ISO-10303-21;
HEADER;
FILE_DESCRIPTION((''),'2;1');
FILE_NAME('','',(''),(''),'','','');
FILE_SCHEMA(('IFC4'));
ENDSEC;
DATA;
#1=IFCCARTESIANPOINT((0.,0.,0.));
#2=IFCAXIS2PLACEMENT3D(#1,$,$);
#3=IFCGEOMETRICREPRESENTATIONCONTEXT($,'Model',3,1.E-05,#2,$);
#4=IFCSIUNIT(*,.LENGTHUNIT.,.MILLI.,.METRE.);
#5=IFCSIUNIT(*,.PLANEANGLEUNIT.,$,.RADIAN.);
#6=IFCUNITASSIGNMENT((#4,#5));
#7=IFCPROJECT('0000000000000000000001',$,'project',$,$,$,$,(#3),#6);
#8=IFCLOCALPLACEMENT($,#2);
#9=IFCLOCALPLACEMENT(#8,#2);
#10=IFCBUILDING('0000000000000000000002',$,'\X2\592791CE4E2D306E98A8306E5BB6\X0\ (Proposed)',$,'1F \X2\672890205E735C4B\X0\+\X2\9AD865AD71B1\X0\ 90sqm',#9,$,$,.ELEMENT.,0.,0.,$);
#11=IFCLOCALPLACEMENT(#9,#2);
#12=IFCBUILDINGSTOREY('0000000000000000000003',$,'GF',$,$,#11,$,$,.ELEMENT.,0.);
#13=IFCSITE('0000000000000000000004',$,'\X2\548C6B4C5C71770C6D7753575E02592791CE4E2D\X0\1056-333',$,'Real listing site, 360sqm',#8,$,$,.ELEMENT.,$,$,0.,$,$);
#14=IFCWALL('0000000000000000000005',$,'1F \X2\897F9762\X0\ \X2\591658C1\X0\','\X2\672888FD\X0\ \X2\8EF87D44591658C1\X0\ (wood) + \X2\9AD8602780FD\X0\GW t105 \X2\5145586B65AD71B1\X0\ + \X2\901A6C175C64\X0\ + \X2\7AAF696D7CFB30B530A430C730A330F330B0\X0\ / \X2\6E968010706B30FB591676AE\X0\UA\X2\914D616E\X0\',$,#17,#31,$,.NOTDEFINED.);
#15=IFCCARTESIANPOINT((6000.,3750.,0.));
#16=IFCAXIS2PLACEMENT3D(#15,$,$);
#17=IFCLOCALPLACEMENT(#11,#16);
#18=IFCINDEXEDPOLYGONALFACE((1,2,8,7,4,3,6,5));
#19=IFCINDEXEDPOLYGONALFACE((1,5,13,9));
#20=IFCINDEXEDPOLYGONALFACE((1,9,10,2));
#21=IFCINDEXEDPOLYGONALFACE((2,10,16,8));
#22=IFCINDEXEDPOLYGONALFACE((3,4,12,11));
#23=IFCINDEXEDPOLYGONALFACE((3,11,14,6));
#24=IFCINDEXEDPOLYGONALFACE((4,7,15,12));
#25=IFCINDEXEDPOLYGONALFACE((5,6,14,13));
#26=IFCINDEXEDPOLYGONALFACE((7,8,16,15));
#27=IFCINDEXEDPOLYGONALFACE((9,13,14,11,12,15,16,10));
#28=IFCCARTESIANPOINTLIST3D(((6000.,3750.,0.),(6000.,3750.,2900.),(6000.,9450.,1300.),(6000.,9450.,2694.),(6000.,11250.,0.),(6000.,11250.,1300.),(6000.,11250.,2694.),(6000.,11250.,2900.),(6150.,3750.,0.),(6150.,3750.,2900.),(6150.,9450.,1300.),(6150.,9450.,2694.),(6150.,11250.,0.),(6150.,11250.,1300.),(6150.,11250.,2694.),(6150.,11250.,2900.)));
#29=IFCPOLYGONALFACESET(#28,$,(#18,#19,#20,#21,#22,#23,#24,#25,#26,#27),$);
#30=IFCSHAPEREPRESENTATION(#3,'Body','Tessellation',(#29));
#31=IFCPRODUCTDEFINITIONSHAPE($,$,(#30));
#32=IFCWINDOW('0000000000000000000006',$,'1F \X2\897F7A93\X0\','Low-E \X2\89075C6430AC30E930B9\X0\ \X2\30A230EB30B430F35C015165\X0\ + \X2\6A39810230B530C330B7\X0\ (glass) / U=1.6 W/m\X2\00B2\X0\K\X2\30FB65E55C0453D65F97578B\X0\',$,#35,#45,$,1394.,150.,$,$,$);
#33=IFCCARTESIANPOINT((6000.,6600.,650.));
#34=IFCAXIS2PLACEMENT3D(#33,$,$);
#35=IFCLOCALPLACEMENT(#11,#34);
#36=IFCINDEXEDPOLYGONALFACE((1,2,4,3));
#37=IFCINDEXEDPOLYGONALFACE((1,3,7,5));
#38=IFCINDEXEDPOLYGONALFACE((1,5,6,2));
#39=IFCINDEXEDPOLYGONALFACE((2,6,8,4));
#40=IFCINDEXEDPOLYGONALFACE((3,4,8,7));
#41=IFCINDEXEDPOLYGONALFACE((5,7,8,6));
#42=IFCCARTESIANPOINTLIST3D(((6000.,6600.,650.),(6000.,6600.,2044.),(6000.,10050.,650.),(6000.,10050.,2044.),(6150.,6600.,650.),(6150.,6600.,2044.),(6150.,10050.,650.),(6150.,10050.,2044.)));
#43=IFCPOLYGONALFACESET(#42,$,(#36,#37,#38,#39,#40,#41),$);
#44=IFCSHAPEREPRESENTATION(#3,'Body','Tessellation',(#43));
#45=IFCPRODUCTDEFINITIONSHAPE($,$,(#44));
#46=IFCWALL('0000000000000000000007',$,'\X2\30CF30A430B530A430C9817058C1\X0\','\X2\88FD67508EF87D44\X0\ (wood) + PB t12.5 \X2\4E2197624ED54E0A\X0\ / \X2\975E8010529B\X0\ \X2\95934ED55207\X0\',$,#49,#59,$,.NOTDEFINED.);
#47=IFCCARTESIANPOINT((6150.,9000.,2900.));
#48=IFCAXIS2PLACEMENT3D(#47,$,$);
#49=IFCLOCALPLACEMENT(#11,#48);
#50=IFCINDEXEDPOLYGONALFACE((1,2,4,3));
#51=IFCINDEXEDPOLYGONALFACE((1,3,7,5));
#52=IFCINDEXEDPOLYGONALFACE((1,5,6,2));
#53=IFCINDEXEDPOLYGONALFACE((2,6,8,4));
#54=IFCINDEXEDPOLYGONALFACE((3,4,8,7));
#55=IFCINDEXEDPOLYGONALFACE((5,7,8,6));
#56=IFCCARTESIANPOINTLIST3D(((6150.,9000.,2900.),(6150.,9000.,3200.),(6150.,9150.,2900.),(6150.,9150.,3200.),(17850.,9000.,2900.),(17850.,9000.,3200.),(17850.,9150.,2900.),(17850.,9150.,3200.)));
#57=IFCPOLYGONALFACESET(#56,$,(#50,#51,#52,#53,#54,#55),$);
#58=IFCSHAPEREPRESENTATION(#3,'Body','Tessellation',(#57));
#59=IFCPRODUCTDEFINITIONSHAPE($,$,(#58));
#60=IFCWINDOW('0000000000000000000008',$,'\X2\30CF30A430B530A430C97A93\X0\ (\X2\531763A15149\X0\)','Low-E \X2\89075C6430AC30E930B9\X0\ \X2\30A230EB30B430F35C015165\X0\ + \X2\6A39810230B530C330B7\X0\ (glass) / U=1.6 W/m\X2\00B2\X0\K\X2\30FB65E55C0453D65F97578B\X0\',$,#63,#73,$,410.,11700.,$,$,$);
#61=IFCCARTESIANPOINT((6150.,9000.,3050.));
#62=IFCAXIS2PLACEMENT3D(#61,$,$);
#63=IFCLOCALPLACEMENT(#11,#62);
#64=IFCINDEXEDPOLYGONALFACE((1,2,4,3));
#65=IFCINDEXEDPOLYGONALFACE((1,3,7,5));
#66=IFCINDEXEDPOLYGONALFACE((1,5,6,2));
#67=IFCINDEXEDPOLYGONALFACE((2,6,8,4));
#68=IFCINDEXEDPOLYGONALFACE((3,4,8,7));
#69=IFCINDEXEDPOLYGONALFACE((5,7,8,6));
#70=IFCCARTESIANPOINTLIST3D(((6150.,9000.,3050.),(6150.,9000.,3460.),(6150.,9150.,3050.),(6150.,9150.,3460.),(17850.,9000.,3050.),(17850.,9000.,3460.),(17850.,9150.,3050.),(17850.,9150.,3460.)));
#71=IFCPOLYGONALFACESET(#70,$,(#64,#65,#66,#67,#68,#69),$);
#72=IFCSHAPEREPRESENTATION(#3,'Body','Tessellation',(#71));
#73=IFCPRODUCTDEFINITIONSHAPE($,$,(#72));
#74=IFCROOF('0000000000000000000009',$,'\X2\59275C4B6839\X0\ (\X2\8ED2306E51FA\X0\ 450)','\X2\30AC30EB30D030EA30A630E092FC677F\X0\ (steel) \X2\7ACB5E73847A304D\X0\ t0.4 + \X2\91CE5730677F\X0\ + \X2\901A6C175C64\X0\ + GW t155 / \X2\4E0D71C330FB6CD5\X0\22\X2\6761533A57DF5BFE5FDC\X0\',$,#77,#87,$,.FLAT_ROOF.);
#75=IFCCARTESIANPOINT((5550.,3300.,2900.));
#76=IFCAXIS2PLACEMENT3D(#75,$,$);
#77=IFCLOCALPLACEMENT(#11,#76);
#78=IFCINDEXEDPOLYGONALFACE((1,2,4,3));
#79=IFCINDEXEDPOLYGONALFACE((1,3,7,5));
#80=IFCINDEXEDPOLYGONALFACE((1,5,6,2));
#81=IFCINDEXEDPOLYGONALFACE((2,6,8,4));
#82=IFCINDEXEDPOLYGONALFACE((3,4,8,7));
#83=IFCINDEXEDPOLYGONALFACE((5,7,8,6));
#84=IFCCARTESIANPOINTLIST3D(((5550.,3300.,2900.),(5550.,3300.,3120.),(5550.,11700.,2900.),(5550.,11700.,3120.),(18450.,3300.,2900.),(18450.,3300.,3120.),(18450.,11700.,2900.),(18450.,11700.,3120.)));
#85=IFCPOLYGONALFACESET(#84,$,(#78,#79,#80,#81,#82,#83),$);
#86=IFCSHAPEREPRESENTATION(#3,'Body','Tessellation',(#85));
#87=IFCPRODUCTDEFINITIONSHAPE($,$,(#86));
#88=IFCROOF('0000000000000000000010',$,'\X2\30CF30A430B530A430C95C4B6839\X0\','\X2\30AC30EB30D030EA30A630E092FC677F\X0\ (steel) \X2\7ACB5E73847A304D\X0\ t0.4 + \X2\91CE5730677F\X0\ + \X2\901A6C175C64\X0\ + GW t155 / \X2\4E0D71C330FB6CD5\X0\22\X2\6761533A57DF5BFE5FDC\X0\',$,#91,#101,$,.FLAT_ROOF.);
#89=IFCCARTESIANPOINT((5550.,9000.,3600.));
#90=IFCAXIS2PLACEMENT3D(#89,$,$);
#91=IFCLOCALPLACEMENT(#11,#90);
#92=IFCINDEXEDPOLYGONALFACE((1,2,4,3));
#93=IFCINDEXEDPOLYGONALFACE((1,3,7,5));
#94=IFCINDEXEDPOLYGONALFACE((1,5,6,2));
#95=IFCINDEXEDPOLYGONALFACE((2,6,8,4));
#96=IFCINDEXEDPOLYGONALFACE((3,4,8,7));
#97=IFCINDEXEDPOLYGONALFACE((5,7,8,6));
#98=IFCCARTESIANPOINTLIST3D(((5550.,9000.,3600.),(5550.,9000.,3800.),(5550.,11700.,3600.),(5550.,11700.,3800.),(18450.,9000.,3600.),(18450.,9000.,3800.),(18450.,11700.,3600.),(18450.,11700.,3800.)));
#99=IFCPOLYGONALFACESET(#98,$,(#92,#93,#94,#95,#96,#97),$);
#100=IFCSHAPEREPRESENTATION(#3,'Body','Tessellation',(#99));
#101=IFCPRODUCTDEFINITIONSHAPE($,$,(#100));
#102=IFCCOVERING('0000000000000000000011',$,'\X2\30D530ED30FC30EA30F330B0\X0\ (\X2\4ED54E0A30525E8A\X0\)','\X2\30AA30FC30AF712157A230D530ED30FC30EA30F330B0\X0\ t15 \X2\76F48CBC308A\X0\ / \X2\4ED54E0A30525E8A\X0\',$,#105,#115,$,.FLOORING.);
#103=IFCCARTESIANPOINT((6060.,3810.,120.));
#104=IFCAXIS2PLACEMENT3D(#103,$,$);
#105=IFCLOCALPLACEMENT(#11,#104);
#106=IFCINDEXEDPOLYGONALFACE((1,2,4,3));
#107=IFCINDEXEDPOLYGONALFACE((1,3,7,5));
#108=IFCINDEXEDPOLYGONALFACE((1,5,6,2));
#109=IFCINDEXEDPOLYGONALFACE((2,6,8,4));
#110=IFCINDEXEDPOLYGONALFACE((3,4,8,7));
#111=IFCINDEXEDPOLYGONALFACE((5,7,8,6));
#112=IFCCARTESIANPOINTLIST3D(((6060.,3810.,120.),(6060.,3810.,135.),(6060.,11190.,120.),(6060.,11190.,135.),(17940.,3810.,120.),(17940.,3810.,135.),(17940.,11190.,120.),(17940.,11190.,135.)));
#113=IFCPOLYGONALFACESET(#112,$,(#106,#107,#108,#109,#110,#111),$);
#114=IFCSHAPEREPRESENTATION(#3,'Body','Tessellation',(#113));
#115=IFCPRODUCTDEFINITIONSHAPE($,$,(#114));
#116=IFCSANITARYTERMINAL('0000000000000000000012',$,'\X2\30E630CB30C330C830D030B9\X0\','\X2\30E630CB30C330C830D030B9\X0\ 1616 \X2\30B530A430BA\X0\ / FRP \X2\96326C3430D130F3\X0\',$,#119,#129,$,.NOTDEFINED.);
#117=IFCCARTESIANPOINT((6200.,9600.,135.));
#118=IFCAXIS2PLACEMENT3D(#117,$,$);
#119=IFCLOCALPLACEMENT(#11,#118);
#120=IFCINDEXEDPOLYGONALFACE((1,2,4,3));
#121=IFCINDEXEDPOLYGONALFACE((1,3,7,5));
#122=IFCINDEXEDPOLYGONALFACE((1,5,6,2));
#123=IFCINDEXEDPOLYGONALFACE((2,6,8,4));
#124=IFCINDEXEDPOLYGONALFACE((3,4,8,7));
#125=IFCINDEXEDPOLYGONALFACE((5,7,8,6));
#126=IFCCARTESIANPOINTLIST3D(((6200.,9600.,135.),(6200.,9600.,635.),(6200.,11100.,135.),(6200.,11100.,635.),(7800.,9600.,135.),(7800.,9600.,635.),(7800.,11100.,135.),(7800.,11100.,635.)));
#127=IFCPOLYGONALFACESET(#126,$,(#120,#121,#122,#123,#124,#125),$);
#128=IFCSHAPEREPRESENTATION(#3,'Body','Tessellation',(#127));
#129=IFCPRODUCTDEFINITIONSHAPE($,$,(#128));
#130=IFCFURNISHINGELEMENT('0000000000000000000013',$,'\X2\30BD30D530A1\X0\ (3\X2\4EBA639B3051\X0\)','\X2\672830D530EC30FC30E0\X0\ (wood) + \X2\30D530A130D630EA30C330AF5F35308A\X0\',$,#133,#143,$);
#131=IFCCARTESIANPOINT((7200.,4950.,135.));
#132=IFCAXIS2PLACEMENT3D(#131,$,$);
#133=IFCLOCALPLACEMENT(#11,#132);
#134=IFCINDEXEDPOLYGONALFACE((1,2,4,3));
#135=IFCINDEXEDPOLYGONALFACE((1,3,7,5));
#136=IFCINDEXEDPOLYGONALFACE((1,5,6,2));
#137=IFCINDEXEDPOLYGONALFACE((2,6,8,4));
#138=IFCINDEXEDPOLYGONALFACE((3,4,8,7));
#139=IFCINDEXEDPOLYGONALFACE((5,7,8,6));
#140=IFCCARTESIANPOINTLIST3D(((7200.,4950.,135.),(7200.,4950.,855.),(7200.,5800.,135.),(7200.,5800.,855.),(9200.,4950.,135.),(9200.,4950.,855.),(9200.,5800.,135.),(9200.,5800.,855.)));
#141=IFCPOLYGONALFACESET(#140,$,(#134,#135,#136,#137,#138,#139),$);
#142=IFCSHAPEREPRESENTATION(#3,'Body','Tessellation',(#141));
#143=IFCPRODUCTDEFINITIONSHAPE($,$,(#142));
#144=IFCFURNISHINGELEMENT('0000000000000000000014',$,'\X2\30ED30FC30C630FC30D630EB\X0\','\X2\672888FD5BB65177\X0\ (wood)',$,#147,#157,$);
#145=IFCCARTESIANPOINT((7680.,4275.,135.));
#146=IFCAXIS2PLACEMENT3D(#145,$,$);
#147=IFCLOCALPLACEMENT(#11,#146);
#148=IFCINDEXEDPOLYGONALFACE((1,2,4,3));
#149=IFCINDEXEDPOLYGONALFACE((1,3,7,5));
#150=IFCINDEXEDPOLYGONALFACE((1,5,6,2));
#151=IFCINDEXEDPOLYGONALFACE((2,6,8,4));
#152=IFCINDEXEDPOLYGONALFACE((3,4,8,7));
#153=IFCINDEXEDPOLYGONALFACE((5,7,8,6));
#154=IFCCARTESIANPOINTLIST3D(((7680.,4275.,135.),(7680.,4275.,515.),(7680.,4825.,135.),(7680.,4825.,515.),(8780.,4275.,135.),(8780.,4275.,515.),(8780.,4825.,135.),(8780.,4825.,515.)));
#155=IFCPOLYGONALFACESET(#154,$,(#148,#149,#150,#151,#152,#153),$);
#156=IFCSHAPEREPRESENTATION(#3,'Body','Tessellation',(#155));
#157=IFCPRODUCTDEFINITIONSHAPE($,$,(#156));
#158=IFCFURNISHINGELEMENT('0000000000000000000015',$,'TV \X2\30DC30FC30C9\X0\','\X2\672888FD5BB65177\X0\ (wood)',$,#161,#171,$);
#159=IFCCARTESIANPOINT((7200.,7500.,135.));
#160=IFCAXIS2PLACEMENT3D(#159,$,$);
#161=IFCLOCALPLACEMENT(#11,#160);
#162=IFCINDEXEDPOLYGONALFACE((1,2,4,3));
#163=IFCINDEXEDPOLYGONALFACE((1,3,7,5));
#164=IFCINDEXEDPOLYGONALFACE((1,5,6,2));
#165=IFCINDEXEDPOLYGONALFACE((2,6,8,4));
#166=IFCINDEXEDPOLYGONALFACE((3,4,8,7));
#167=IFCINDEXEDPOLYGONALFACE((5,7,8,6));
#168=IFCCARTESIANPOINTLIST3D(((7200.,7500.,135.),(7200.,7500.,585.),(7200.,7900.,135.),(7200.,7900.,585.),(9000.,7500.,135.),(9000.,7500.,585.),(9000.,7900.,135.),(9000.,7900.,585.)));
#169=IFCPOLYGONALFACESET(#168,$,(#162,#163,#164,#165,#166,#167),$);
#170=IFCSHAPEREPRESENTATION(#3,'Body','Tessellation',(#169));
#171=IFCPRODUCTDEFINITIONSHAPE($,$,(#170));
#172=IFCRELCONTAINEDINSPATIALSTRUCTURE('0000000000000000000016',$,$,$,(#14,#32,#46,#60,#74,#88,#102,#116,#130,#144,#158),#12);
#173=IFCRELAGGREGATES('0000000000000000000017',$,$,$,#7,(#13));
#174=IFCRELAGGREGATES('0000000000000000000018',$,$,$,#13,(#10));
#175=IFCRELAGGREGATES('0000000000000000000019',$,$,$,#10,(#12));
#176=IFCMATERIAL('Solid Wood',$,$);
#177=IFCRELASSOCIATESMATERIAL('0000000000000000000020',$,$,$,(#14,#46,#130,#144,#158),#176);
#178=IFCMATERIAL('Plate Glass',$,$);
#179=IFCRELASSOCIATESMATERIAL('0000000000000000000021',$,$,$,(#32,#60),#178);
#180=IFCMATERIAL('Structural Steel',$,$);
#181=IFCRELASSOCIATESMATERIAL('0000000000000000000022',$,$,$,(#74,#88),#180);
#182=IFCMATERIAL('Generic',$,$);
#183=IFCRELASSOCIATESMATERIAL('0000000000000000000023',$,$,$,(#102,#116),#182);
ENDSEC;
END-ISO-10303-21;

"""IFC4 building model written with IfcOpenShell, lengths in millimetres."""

from ifc_helpers import new_model, si_unit, frame, frame_2d, origin, place, context, project, spatial, rectangle, extrude, material, element, fill, save


model = new_model("IFC4")

# Units and contexts
model_context = context("Model", 3, precision=1e-05, world=origin())
ifc_project = project(units=[si_unit("LENGTHUNIT", "METRE", prefix="MILLI"), si_unit("PLANEANGLEUNIT", "RADIAN")], contexts=[model_context])

# Site, building, storey
site_placement = place(None, origin())
site = spatial("IfcSite", under=ifc_project, at=site_placement, Name="和歌山県海南市大野中1056-333", ObjectType="Real listing site, 360sqm", CompositionType="ELEMENT", RefElevation=0.0)
building_placement = place(site_placement, origin())
building = spatial("IfcBuilding", under=site, at=building_placement, Name="大野中の風の家 (Proposed)", ObjectType="1F 木造平屋+高断熱 90sqm", CompositionType="ELEMENT", ElevationOfRefHeight=0.0, ElevationOfTerrain=0.0)
storey_placement = place(building_placement, origin())
storey = spatial("IfcBuildingStorey", under=building, at=storey_placement, Name="GF", CompositionType="ELEMENT", Elevation=0.0)

# Shared definitions
ifc_material_1 = material(Name="Solid Wood")

# Shared definitions
ifc_material_2 = material(Name="Plate Glass")

# Wall, opening, window
wall_1_placement = place(storey_placement, frame((6000.0, 3750.0, 0.0)))
wall_1 = element("IfcWall", 1, at=wall_1_placement, inside=storey, material=ifc_material_1, Name="1F 西面 外壁", Description="木製 軸組外壁 (wood) + 高性能GW t105 充填断熱 + 通気層 + 窯業系サイディング / 準耐火・外皮UA配慮", PredefinedType="NOTDEFINED", context=model_context, shape_type="SweptSolid", body=[
    extrude(rectangle(XDim=150.0, YDim=7500.0, at=frame_2d((75.0, 3750.0))), frame((6000.0, 3750.0, 0.0)), (0.0, 0.0, 1.0), 2900.0),
])
opening_1_placement = place(storey_placement, frame((6000.0, 6600.0, 650.0)))
opening_1 = element("IfcOpeningElement", 2, at=opening_1_placement, cuts=wall_1, PredefinedType="NOTDEFINED", context=model_context, shape_type="SweptSolid", body=[
    extrude(rectangle(XDim=150.0, YDim=3450.0, at=frame_2d((75.0, 1725.0))), frame((6000.0, 6600.0, 650.0)), (0.0, 0.0, 1.0), 1394.0),
])
window_1_placement = place(storey_placement, frame((6000.0, 6600.0, 650.0)))
window_1 = element("IfcWindow", 3, at=window_1_placement, inside=storey, material=ifc_material_2, Name="1F 西窓", Description="Low-E 複層ガラス アルゴン封入 + 樹脂サッシ (glass) / U=1.6 W/m²K・日射取得型", OverallHeight=1394.0, OverallWidth=150.0, context=model_context, shape_type="SweptSolid", body=[
    extrude(rectangle(XDim=150.0, YDim=3450.0, at=frame_2d((75.0, 1725.0))), frame((6000.0, 6600.0, 650.0)), (0.0, 0.0, 1.0), 1394.0),
])
fill(opening_1, window_1)

# Wall, opening, window
wall_2_placement = place(storey_placement, frame((6150.0, 9000.0, 2900.0)))
wall_2 = element("IfcWall", 4, at=wall_2_placement, inside=storey, material=ifc_material_1, Name="ハイサイド腰壁", Description="製材軸組 (wood) + PB t12.5 両面仕上 / 非耐力 間仕切", PredefinedType="NOTDEFINED", context=model_context, shape_type="SweptSolid", body=[
    extrude(rectangle(XDim=11700.0, YDim=150.0, at=frame_2d((5850.0, 75.0))), frame((6150.0, 9000.0, 2900.0)), (0.0, 0.0, 1.0), 700.0),
])
opening_2_placement = place(storey_placement, frame((6150.0, 9000.0, 3050.0)))
opening_2 = element("IfcOpeningElement", 5, at=opening_2_placement, cuts=wall_2, PredefinedType="NOTDEFINED", context=model_context, shape_type="SweptSolid", body=[
    extrude(rectangle(XDim=11700.0, YDim=150.0, at=frame_2d((5850.0, 75.0))), frame((6150.0, 9000.0, 3050.0)), (0.0, 0.0, 1.0), 410.0),
])
window_2_placement = place(storey_placement, frame((6150.0, 9000.0, 3050.0)))
window_2 = element("IfcWindow", 6, at=window_2_placement, inside=storey, material=ifc_material_2, Name="ハイサイド窓 (北採光)", Description="Low-E 複層ガラス アルゴン封入 + 樹脂サッシ (glass) / U=1.6 W/m²K・日射取得型", OverallHeight=410.0, OverallWidth=11700.0, context=model_context, shape_type="SweptSolid", body=[
    extrude(rectangle(XDim=11700.0, YDim=150.0, at=frame_2d((5850.0, 75.0))), frame((6150.0, 9000.0, 3050.0)), (0.0, 0.0, 1.0), 410.0),
])
fill(opening_2, window_2)

# Roofs
ifc_material_3 = material(Name="Structural Steel")
roof_1_placement = place(storey_placement, frame((5550.0, 3300.0, 2900.0)))
element("IfcRoof", 7, at=roof_1_placement, inside=storey, material=ifc_material_3, Name="大屋根 (軒の出 450)", Description="ガルバリウム鋼板 (steel) 立平葺き t0.4 + 野地板 + 通気層 + GW t155 / 不燃・法22条区域対応", PredefinedType="FLAT_ROOF", context=model_context, shape_type="SweptSolid", body=[
    extrude(rectangle(XDim=12900.0, YDim=8400.0, at=frame_2d((6450.0, 4200.0))), frame((5550.0, 3300.0, 2900.0)), (0.0, 0.0, 1.0), 220.0),
])
roof_2_placement = place(storey_placement, frame((5550.0, 9000.0, 3600.0)))
element("IfcRoof", 8, at=roof_2_placement, inside=storey, material=ifc_material_3, Name="ハイサイド屋根", Description="ガルバリウム鋼板 (steel) 立平葺き t0.4 + 野地板 + 通気層 + GW t155 / 不燃・法22条区域対応", PredefinedType="FLAT_ROOF", context=model_context, shape_type="SweptSolid", body=[
    extrude(rectangle(XDim=12900.0, YDim=2700.0, at=frame_2d((6450.0, 1350.0))), frame((5550.0, 9000.0, 3600.0)), (0.0, 0.0, 1.0), 200.0),
])

# Covering
ifc_material_4 = material(Name="Generic")
covering_placement = place(storey_placement, frame((6060.0, 3810.0, 120.0)))
element("IfcCovering", 9, at=covering_placement, inside=storey, material=ifc_material_4, Name="フローリング (仕上げ床)", Description="オーク無垢フローリング t15 直貼り / 仕上げ床", PredefinedType="FLOORING", context=model_context, shape_type="SweptSolid", body=[
    extrude(rectangle(XDim=11880.0, YDim=7380.0, at=frame_2d((5940.0, 3690.0))), frame((6060.0, 3810.0, 120.0)), (0.0, 0.0, 1.0), 15.0),
])

# Sanitary terminal
sanitary_terminal_placement = place(storey_placement, frame((6200.0, 9600.0, 135.0)))
element("IfcSanitaryTerminal", 10, at=sanitary_terminal_placement, inside=storey, material=ifc_material_4, Name="ユニットバス", Description="ユニットバス 1616 サイズ / FRP 防水パン", PredefinedType="NOTDEFINED", context=model_context, shape_type="SweptSolid", body=[
    extrude(rectangle(XDim=1600.0, YDim=1500.0, at=frame_2d((800.0, 750.0))), frame((6200.0, 9600.0, 135.0)), (0.0, 0.0, 1.0), 500.0),
])

# Furnishing elements
furnishing_1_placement = place(storey_placement, frame((7200.0, 4950.0, 135.0)))
element("IfcFurnishingElement", 11, at=furnishing_1_placement, inside=storey, material=ifc_material_1, Name="ソファ (3人掛け)", Description="木フレーム (wood) + ファブリック張り", context=model_context, shape_type="SweptSolid", body=[
    extrude(rectangle(XDim=2000.0, YDim=850.0, at=frame_2d((1000.0, 425.0))), frame((7200.0, 4950.0, 135.0)), (0.0, 0.0, 1.0), 720.0),
])
furnishing_2_placement = place(storey_placement, frame((7680.0, 4275.0, 135.0)))
element("IfcFurnishingElement", 12, at=furnishing_2_placement, inside=storey, material=ifc_material_1, Name="ローテーブル", Description="木製家具 (wood)", context=model_context, shape_type="SweptSolid", body=[
    extrude(rectangle(XDim=1100.0, YDim=550.0, at=frame_2d((550.0, 275.0))), frame((7680.0, 4275.0, 135.0)), (0.0, 0.0, 1.0), 380.0),
])
furnishing_3_placement = place(storey_placement, frame((7200.0, 7500.0, 135.0)))
element("IfcFurnishingElement", 13, at=furnishing_3_placement, inside=storey, material=ifc_material_1, Name="TV ボード", Description="木製家具 (wood)", context=model_context, shape_type="SweptSolid", body=[
    extrude(rectangle(XDim=1800.0, YDim=400.0, at=frame_2d((900.0, 200.0))), frame((7200.0, 7500.0, 135.0)), (0.0, 0.0, 1.0), 450.0),
])

save(model, "model.ifc")
